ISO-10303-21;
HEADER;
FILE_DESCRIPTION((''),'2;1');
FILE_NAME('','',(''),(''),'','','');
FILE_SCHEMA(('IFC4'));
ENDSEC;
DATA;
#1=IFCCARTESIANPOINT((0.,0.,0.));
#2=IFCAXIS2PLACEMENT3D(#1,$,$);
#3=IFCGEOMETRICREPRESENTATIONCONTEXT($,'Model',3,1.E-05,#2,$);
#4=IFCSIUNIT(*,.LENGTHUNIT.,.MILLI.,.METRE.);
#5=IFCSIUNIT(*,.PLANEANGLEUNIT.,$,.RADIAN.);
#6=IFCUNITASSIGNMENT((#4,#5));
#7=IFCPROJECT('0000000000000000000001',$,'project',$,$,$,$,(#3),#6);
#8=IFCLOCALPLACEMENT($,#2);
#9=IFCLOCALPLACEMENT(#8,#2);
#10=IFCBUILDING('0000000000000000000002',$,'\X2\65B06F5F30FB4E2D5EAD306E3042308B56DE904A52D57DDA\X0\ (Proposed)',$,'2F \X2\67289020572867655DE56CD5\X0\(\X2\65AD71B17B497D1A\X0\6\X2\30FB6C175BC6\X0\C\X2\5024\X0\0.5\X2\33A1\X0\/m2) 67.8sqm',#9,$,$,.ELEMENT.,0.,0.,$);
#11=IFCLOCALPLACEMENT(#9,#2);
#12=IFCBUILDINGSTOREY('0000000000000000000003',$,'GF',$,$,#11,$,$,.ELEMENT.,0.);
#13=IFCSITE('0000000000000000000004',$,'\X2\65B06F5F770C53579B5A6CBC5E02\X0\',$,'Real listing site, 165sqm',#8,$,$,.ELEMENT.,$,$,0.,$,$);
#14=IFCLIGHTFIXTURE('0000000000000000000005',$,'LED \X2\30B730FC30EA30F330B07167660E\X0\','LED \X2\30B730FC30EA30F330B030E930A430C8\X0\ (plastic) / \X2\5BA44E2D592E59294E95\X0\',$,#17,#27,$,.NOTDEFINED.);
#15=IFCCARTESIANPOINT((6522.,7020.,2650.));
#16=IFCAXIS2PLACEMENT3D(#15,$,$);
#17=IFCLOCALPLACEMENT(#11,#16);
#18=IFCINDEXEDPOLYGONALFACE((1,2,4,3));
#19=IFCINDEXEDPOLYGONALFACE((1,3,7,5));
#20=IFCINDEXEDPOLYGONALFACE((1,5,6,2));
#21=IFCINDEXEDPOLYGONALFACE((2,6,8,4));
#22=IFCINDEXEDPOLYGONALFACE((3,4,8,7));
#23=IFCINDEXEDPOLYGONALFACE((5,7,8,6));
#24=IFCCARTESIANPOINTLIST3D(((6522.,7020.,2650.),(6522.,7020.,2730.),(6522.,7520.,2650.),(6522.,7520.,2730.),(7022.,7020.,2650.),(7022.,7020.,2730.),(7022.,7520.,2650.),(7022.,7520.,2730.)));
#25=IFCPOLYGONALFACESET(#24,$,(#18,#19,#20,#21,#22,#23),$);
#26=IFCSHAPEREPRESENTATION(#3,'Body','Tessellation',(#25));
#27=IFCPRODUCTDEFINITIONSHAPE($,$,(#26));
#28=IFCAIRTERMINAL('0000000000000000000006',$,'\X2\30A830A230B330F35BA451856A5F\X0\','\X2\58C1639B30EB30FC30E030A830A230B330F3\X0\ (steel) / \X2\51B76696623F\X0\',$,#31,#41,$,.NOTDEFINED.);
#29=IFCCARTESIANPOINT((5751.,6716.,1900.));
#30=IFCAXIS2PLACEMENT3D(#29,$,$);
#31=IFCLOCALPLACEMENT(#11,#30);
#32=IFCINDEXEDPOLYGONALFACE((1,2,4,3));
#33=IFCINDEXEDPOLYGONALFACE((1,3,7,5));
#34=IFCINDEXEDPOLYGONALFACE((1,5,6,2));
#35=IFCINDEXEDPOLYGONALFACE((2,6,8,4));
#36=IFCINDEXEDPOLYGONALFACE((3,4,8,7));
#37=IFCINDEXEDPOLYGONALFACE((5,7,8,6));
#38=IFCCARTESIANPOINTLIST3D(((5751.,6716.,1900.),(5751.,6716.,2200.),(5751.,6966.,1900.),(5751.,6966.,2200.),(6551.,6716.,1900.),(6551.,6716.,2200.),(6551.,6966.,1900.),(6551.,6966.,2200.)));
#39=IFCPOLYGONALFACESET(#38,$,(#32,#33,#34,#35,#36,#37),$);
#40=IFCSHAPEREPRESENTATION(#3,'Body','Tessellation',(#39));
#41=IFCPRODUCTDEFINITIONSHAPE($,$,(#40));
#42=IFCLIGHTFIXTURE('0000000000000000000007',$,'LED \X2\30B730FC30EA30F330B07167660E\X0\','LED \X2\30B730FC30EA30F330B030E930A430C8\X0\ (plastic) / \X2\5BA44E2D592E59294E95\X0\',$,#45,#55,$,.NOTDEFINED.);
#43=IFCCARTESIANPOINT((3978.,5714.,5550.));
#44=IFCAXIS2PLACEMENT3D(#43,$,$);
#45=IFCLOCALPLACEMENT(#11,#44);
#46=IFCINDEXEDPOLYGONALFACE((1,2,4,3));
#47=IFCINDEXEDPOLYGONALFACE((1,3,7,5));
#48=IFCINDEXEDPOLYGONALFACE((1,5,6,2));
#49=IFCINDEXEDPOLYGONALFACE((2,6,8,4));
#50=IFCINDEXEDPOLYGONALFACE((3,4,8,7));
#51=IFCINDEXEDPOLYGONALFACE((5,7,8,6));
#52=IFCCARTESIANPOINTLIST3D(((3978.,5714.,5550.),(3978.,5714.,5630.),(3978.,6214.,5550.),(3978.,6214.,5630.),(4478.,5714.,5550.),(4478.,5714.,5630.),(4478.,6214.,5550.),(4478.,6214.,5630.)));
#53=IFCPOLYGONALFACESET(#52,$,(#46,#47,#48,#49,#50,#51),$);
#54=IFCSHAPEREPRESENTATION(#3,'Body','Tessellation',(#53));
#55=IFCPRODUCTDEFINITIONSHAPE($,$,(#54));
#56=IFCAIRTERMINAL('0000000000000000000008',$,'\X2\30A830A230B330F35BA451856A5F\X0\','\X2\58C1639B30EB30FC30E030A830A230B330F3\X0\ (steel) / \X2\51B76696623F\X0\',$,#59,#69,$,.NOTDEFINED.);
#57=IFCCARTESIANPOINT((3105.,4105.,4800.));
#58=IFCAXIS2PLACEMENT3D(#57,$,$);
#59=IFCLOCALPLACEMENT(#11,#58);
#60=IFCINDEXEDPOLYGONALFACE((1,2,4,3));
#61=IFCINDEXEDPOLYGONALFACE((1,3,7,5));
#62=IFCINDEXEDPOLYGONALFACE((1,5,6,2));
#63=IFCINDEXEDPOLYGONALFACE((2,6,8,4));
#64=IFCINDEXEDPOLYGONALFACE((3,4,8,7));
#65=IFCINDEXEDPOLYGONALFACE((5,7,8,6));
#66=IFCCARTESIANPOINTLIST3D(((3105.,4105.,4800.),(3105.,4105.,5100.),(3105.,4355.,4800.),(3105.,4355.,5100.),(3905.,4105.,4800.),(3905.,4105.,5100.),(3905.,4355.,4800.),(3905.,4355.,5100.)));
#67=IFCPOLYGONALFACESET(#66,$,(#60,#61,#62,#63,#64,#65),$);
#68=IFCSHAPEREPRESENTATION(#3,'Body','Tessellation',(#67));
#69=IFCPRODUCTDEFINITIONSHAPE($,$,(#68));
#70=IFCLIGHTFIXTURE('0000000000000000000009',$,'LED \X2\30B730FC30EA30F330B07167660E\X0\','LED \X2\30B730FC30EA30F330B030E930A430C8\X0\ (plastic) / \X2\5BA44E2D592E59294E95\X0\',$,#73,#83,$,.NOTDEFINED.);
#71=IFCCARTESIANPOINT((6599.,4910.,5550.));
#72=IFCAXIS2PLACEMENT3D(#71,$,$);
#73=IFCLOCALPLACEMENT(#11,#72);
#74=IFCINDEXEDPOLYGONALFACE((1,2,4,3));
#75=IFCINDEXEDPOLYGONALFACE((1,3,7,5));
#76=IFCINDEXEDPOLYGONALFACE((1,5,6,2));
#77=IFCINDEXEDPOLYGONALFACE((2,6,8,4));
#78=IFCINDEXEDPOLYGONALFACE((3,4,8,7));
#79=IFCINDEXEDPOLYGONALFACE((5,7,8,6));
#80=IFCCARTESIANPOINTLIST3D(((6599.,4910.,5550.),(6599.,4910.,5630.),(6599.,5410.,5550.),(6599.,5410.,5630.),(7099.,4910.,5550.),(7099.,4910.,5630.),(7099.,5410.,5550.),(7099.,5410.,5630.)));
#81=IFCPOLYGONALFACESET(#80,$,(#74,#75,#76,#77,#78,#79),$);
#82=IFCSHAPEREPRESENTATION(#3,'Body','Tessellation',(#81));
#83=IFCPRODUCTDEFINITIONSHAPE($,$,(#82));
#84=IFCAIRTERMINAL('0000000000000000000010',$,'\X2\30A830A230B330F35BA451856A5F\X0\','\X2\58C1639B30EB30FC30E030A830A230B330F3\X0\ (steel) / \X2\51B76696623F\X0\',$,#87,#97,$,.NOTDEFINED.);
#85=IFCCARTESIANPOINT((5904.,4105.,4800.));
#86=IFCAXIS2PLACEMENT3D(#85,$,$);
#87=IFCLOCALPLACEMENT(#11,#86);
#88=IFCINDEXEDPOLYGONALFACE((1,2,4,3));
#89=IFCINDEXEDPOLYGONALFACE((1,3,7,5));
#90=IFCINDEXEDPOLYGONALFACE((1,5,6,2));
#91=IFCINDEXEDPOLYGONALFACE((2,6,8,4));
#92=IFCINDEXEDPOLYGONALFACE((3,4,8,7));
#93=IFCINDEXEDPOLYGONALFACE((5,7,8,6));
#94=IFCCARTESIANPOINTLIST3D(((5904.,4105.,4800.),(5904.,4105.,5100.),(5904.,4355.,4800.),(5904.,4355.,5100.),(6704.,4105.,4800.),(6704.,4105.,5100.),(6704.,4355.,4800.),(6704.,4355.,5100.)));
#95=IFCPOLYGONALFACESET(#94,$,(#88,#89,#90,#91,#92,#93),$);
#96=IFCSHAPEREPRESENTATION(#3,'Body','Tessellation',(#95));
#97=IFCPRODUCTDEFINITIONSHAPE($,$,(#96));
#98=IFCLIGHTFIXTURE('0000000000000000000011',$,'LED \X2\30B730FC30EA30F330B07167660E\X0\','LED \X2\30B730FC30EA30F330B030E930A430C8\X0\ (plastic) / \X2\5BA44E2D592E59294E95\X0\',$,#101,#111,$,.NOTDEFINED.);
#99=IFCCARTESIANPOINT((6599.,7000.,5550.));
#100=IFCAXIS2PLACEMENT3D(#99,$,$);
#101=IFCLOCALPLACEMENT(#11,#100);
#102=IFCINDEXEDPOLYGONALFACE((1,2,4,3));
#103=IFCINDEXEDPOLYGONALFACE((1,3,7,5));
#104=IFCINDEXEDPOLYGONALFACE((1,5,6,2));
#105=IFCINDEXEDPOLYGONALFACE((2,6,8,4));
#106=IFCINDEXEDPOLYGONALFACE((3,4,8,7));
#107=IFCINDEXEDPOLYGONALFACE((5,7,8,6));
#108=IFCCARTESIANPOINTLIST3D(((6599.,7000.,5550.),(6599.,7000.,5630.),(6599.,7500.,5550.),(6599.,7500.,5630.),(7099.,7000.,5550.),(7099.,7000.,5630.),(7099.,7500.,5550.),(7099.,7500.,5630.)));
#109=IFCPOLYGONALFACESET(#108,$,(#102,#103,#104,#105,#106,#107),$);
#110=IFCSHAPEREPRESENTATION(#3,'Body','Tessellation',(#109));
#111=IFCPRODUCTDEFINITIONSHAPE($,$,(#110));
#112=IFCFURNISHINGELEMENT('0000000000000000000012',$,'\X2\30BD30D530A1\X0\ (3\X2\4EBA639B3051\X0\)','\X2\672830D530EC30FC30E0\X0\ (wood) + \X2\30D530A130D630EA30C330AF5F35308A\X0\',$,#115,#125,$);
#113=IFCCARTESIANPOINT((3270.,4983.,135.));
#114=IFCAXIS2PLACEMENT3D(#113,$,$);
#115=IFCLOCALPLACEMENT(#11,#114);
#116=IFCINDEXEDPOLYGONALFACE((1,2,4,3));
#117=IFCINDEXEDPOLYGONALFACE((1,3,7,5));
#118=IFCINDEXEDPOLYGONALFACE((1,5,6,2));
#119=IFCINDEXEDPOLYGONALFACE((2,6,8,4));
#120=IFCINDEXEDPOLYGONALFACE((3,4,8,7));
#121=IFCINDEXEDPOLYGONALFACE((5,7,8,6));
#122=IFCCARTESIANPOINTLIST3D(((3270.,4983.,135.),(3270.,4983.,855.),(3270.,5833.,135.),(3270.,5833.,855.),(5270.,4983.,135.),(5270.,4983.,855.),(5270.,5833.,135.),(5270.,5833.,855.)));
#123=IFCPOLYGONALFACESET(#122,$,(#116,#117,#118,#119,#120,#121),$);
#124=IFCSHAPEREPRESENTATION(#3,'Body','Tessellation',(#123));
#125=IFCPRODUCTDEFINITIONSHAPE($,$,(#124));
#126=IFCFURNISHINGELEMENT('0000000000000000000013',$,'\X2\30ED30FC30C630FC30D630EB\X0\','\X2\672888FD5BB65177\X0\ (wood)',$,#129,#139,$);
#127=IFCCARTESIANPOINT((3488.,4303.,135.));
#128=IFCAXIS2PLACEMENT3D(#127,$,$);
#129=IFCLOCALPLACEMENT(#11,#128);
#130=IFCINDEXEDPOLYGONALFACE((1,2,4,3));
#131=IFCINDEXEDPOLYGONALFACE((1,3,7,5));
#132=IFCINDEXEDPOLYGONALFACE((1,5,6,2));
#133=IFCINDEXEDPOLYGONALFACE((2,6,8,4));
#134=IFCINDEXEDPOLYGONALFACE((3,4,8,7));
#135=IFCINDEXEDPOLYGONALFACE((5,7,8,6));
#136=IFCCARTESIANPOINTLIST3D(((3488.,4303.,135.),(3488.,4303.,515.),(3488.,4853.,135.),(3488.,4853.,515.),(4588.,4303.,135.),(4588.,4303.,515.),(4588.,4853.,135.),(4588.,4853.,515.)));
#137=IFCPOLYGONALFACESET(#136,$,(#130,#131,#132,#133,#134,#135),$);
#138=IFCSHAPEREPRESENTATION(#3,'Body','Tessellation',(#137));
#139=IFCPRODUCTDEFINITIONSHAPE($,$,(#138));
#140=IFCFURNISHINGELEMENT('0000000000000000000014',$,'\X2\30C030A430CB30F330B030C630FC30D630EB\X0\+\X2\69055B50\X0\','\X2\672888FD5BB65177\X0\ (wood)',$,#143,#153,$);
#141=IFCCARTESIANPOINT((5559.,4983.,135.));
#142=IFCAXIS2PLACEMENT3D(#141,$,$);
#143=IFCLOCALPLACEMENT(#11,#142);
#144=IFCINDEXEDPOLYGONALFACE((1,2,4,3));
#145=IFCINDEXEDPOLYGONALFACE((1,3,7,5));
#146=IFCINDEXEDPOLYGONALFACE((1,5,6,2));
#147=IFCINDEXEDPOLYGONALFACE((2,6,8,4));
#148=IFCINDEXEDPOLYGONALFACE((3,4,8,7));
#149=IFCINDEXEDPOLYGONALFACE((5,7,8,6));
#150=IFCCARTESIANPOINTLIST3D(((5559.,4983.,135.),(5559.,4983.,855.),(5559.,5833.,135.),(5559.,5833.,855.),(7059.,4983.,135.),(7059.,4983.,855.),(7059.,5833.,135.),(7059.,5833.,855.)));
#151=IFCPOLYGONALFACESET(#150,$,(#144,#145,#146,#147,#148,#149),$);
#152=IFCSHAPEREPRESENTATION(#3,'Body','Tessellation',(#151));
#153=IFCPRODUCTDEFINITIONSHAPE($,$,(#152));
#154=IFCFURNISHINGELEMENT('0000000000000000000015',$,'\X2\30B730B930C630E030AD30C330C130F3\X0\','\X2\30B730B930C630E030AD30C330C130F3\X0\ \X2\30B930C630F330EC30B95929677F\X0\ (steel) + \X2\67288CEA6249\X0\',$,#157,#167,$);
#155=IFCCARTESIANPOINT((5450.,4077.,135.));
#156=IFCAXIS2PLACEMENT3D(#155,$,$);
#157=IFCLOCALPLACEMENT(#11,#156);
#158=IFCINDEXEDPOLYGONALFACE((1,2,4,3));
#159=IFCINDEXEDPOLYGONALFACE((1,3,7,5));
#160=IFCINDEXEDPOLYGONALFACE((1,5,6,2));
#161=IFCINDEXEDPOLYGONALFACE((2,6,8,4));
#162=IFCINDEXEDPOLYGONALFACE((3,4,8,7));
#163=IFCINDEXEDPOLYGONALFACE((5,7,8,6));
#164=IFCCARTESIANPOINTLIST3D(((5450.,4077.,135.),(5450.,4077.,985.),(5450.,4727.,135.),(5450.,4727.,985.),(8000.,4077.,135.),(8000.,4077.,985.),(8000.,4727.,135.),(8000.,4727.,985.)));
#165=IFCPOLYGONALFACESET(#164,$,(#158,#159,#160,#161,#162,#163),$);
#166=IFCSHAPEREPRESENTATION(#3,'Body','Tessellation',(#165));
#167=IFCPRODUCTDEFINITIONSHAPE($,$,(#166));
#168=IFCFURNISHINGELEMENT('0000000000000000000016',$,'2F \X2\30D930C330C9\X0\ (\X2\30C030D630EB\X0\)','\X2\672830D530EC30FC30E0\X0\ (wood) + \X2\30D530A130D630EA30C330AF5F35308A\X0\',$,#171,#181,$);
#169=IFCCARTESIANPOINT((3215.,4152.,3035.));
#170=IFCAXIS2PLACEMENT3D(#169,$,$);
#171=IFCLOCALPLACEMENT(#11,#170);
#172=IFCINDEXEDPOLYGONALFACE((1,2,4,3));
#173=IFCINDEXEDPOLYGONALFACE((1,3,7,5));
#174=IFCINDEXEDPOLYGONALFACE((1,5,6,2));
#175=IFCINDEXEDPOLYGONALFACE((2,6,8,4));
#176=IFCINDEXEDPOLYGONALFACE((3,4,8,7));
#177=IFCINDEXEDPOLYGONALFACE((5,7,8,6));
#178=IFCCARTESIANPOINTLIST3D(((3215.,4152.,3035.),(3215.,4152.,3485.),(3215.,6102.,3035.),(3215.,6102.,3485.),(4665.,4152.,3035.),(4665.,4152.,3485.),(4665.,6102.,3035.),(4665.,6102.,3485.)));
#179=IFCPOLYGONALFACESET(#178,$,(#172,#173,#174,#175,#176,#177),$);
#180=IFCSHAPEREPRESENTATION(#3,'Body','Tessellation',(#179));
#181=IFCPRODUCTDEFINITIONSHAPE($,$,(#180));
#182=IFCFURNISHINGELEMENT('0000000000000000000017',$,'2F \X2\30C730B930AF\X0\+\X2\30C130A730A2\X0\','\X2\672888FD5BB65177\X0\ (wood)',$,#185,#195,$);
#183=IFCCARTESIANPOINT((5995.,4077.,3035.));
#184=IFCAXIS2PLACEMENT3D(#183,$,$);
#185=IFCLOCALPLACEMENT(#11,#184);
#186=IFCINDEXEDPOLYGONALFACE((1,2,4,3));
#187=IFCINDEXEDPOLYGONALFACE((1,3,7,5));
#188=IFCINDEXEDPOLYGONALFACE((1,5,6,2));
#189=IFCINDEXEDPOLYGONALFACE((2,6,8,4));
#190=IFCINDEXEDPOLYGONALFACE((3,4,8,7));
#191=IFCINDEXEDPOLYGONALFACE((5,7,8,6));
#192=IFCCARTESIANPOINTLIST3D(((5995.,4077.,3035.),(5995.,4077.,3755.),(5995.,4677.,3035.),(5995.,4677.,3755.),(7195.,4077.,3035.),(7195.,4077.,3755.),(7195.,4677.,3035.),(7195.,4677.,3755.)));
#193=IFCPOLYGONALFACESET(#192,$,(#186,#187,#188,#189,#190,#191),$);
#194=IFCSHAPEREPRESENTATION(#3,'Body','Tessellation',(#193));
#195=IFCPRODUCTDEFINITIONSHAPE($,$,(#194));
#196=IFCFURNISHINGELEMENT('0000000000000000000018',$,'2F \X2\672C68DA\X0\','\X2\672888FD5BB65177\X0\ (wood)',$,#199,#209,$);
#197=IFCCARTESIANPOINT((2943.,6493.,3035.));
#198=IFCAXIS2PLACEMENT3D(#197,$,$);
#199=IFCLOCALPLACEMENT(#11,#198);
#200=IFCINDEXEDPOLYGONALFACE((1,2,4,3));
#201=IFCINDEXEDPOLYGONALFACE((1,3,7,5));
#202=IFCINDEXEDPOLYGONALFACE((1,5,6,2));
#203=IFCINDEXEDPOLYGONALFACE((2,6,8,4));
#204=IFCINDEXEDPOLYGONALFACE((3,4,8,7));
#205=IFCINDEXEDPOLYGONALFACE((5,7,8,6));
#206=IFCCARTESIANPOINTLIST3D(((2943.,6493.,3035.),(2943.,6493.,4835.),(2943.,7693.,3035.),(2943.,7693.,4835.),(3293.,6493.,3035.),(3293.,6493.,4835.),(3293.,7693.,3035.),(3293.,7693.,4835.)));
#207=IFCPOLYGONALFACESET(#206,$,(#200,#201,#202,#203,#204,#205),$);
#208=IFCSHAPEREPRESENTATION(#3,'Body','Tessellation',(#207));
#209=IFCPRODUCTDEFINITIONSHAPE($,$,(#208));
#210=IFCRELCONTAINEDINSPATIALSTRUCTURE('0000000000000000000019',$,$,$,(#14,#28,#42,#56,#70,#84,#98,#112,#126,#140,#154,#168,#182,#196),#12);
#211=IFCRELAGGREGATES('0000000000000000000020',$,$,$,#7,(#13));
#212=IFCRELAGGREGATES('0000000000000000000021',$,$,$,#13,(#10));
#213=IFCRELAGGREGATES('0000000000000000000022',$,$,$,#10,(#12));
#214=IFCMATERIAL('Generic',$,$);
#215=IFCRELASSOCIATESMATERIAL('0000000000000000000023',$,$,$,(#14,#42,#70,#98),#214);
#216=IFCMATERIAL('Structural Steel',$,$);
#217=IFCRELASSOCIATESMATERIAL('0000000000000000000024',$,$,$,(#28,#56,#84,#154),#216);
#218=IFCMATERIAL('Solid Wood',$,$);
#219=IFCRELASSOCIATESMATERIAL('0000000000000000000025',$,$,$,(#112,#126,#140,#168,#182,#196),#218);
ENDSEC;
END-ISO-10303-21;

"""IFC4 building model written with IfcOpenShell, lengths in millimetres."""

from ifc_helpers import new_model, si_unit, frame, frame_2d, origin, place, context, project, spatial, rectangle, extrude, material, element, save


model = new_model("IFC4")

# Units and contexts
model_context = context("Model", 3, precision=1e-05, world=origin())
ifc_project = project(units=[si_unit("LENGTHUNIT", "METRE", prefix="MILLI"), si_unit("PLANEANGLEUNIT", "RADIAN")], contexts=[model_context])

# Site, building, storey
site_placement = place(None, origin())
site = spatial("IfcSite", under=ifc_project, at=site_placement, Name="新潟県南魚沼市", ObjectType="Real listing site, 165sqm", CompositionType="ELEMENT", RefElevation=0.0)
building_placement = place(site_placement, origin())
building = spatial("IfcBuilding", under=site, at=building_placement, Name="新潟・中庭のある回遊動線 (Proposed)", ObjectType="2F 木造在来工法(断熱等級6・気密C値0.5㎡/m2) 67.8sqm", CompositionType="ELEMENT", ElevationOfRefHeight=0.0, ElevationOfTerrain=0.0)
storey_placement = place(building_placement, origin())
storey = spatial("IfcBuildingStorey", under=building, at=storey_placement, Name="GF", CompositionType="ELEMENT", Elevation=0.0)

# Shared definitions
ifc_material_1 = material(Name="Solid Wood")

# Shared definitions
ifc_material_2 = material(Name="Structural Steel")

# Shared definitions
ifc_material_3 = material(Name="Generic")

# Light fixture
light_fixture_1_placement = place(storey_placement, frame((6522.0, 7020.0, 2650.0)))
element("IfcLightFixture", 1, at=light_fixture_1_placement, inside=storey, material=ifc_material_3, Name="LED シーリング照明", Description="LED シーリングライト (plastic) / 室中央天井", PredefinedType="NOTDEFINED", context=model_context, shape_type="SweptSolid", body=[
    extrude(rectangle(XDim=500.0, YDim=500.0, at=frame_2d((250.0, 250.0))), frame((6522.0, 7020.0, 2650.0)), (0.0, 0.0, 1.0), 80.0),
])

# Air terminal
air_terminal_1_placement = place(storey_placement, frame((5751.0, 6716.0, 1900.0)))
element("IfcAirTerminal", 2, at=air_terminal_1_placement, inside=storey, material=ifc_material_2, Name="エアコン室内機", Description="壁掛ルームエアコン (steel) / 冷暖房", PredefinedType="NOTDEFINED", context=model_context, shape_type="SweptSolid", body=[
    extrude(rectangle(XDim=800.0, YDim=250.0, at=frame_2d((400.0, 125.0))), frame((5751.0, 6716.0, 1900.0)), (0.0, 0.0, 1.0), 300.0),
])

# Light fixture
light_fixture_2_placement = place(storey_placement, frame((3978.0, 5714.0, 5550.0)))
element("IfcLightFixture", 3, at=light_fixture_2_placement, inside=storey, material=ifc_material_3, Name="LED シーリング照明", Description="LED シーリングライト (plastic) / 室中央天井", PredefinedType="NOTDEFINED", context=model_context, shape_type="SweptSolid", body=[
    extrude(rectangle(XDim=500.0, YDim=500.0, at=frame_2d((250.0, 250.0))), frame((3978.0, 5714.0, 5550.0)), (0.0, 0.0, 1.0), 80.0),
])

# Air terminal
air_terminal_2_placement = place(storey_placement, frame((3105.0, 4105.0, 4800.0)))
element("IfcAirTerminal", 4, at=air_terminal_2_placement, inside=storey, material=ifc_material_2, Name="エアコン室内機", Description="壁掛ルームエアコン (steel) / 冷暖房", PredefinedType="NOTDEFINED", context=model_context, shape_type="SweptSolid", body=[
    extrude(rectangle(XDim=800.0, YDim=250.0, at=frame_2d((400.0, 125.0))), frame((3105.0, 4105.0, 4800.0)), (0.0, 0.0, 1.0), 300.0),
])

# Light fixture
light_fixture_3_placement = place(storey_placement, frame((6599.0, 4910.0, 5550.0)))
element("IfcLightFixture", 5, at=light_fixture_3_placement, inside=storey, material=ifc_material_3, Name="LED シーリング照明", Description="LED シーリングライト (plastic) / 室中央天井", PredefinedType="NOTDEFINED", context=model_context, shape_type="SweptSolid", body=[
    extrude(rectangle(XDim=500.0, YDim=500.0, at=frame_2d((250.0, 250.0))), frame((6599.0, 4910.0, 5550.0)), (0.0, 0.0, 1.0), 80.0),
])

# Air terminal
air_terminal_3_placement = place(storey_placement, frame((5904.0, 4105.0, 4800.0)))
element("IfcAirTerminal", 6, at=air_terminal_3_placement, inside=storey, material=ifc_material_2, Name="エアコン室内機", Description="壁掛ルームエアコン (steel) / 冷暖房", PredefinedType="NOTDEFINED", context=model_context, shape_type="SweptSolid", body=[
    extrude(rectangle(XDim=800.0, YDim=250.0, at=frame_2d((400.0, 125.0))), frame((5904.0, 4105.0, 4800.0)), (0.0, 0.0, 1.0), 300.0),
])

# Light fixture
light_fixture_4_placement = place(storey_placement, frame((6599.0, 7000.0, 5550.0)))
element("IfcLightFixture", 7, at=light_fixture_4_placement, inside=storey, material=ifc_material_3, Name="LED シーリング照明", Description="LED シーリングライト (plastic) / 室中央天井", PredefinedType="NOTDEFINED", context=model_context, shape_type="SweptSolid", body=[
    extrude(rectangle(XDim=500.0, YDim=500.0, at=frame_2d((250.0, 250.0))), frame((6599.0, 7000.0, 5550.0)), (0.0, 0.0, 1.0), 80.0),
])

# Furnishing elements
furnishing_1_placement = place(storey_placement, frame((3270.0, 4983.0, 135.0)))
element("IfcFurnishingElement", 8, at=furnishing_1_placement, inside=storey, material=ifc_material_1, Name="ソファ (3人掛け)", Description="木フレーム (wood) + ファブリック張り", context=model_context, shape_type="SweptSolid", body=[
    extrude(rectangle(XDim=2000.0, YDim=850.0, at=frame_2d((1000.0, 425.0))), frame((3270.0, 4983.0, 135.0)), (0.0, 0.0, 1.0), 720.0),
])
furnishing_2_placement = place(storey_placement, frame((3488.0, 4303.0, 135.0)))
element("IfcFurnishingElement", 9, at=furnishing_2_placement, inside=storey, material=ifc_material_1, Name="ローテーブル", Description="木製家具 (wood)", context=model_context, shape_type="SweptSolid", body=[
    extrude(rectangle(XDim=1100.0, YDim=550.0, at=frame_2d((550.0, 275.0))), frame((3488.0, 4303.0, 135.0)), (0.0, 0.0, 1.0), 380.0),
])
furnishing_3_placement = place(storey_placement, frame((5559.0, 4983.0, 135.0)))
element("IfcFurnishingElement", 10, at=furnishing_3_placement, inside=storey, material=ifc_material_1, Name="ダイニングテーブル+椅子", Description="木製家具 (wood)", context=model_context, shape_type="SweptSolid", body=[
    extrude(rectangle(XDim=1500.0, YDim=850.0, at=frame_2d((750.0, 425.0))), frame((5559.0, 4983.0, 135.0)), (0.0, 0.0, 1.0), 720.0),
])
furnishing_4_placement = place(storey_placement, frame((5450.0, 4077.0, 135.0)))
element("IfcFurnishingElement", 11, at=furnishing_4_placement, inside=storey, material=ifc_material_2, Name="システムキッチン", Description="システムキッチン ステンレス天板 (steel) + 木質扉", context=model_context, shape_type="SweptSolid", body=[
    extrude(rectangle(XDim=2550.0, YDim=650.0, at=frame_2d((1275.0, 325.0))), frame((5450.0, 4077.0, 135.0)), (0.0, 0.0, 1.0), 850.0),
])
furnishing_5_placement = place(storey_placement, frame((3215.0, 4152.0, 3035.0)))
element("IfcFurnishingElement", 12, at=furnishing_5_placement, inside=storey, material=ifc_material_1, Name="2F ベッド (ダブル)", Description="木フレーム (wood) + ファブリック張り", context=model_context, shape_type="SweptSolid", body=[
    extrude(rectangle(XDim=1450.0, YDim=1950.0, at=frame_2d((725.0, 975.0))), frame((3215.0, 4152.0, 3035.0)), (0.0, 0.0, 1.0), 450.0),
])
furnishing_6_placement = place(storey_placement, frame((5995.0, 4077.0, 3035.0)))
element("IfcFurnishingElement", 13, at=furnishing_6_placement, inside=storey, material=ifc_material_1, Name="2F デスク+チェア", Description="木製家具 (wood)", context=model_context, shape_type="SweptSolid", body=[
    extrude(rectangle(XDim=1200.0, YDim=600.0, at=frame_2d((600.0, 300.0))), frame((5995.0, 4077.0, 3035.0)), (0.0, 0.0, 1.0), 720.0),
])
furnishing_7_placement = place(storey_placement, frame((2943.0, 6493.0, 3035.0)))
element("IfcFurnishingElement", 14, at=furnishing_7_placement, inside=storey, material=ifc_material_1, Name="2F 本棚", Description="木製家具 (wood)", context=model_context, shape_type="SweptSolid", body=[
    extrude(rectangle(XDim=350.0, YDim=1200.0, at=frame_2d((175.0, 600.0))), frame((2943.0, 6493.0, 3035.0)), (0.0, 0.0, 1.0), 1800.0),
])

save(model, "model.ifc")
